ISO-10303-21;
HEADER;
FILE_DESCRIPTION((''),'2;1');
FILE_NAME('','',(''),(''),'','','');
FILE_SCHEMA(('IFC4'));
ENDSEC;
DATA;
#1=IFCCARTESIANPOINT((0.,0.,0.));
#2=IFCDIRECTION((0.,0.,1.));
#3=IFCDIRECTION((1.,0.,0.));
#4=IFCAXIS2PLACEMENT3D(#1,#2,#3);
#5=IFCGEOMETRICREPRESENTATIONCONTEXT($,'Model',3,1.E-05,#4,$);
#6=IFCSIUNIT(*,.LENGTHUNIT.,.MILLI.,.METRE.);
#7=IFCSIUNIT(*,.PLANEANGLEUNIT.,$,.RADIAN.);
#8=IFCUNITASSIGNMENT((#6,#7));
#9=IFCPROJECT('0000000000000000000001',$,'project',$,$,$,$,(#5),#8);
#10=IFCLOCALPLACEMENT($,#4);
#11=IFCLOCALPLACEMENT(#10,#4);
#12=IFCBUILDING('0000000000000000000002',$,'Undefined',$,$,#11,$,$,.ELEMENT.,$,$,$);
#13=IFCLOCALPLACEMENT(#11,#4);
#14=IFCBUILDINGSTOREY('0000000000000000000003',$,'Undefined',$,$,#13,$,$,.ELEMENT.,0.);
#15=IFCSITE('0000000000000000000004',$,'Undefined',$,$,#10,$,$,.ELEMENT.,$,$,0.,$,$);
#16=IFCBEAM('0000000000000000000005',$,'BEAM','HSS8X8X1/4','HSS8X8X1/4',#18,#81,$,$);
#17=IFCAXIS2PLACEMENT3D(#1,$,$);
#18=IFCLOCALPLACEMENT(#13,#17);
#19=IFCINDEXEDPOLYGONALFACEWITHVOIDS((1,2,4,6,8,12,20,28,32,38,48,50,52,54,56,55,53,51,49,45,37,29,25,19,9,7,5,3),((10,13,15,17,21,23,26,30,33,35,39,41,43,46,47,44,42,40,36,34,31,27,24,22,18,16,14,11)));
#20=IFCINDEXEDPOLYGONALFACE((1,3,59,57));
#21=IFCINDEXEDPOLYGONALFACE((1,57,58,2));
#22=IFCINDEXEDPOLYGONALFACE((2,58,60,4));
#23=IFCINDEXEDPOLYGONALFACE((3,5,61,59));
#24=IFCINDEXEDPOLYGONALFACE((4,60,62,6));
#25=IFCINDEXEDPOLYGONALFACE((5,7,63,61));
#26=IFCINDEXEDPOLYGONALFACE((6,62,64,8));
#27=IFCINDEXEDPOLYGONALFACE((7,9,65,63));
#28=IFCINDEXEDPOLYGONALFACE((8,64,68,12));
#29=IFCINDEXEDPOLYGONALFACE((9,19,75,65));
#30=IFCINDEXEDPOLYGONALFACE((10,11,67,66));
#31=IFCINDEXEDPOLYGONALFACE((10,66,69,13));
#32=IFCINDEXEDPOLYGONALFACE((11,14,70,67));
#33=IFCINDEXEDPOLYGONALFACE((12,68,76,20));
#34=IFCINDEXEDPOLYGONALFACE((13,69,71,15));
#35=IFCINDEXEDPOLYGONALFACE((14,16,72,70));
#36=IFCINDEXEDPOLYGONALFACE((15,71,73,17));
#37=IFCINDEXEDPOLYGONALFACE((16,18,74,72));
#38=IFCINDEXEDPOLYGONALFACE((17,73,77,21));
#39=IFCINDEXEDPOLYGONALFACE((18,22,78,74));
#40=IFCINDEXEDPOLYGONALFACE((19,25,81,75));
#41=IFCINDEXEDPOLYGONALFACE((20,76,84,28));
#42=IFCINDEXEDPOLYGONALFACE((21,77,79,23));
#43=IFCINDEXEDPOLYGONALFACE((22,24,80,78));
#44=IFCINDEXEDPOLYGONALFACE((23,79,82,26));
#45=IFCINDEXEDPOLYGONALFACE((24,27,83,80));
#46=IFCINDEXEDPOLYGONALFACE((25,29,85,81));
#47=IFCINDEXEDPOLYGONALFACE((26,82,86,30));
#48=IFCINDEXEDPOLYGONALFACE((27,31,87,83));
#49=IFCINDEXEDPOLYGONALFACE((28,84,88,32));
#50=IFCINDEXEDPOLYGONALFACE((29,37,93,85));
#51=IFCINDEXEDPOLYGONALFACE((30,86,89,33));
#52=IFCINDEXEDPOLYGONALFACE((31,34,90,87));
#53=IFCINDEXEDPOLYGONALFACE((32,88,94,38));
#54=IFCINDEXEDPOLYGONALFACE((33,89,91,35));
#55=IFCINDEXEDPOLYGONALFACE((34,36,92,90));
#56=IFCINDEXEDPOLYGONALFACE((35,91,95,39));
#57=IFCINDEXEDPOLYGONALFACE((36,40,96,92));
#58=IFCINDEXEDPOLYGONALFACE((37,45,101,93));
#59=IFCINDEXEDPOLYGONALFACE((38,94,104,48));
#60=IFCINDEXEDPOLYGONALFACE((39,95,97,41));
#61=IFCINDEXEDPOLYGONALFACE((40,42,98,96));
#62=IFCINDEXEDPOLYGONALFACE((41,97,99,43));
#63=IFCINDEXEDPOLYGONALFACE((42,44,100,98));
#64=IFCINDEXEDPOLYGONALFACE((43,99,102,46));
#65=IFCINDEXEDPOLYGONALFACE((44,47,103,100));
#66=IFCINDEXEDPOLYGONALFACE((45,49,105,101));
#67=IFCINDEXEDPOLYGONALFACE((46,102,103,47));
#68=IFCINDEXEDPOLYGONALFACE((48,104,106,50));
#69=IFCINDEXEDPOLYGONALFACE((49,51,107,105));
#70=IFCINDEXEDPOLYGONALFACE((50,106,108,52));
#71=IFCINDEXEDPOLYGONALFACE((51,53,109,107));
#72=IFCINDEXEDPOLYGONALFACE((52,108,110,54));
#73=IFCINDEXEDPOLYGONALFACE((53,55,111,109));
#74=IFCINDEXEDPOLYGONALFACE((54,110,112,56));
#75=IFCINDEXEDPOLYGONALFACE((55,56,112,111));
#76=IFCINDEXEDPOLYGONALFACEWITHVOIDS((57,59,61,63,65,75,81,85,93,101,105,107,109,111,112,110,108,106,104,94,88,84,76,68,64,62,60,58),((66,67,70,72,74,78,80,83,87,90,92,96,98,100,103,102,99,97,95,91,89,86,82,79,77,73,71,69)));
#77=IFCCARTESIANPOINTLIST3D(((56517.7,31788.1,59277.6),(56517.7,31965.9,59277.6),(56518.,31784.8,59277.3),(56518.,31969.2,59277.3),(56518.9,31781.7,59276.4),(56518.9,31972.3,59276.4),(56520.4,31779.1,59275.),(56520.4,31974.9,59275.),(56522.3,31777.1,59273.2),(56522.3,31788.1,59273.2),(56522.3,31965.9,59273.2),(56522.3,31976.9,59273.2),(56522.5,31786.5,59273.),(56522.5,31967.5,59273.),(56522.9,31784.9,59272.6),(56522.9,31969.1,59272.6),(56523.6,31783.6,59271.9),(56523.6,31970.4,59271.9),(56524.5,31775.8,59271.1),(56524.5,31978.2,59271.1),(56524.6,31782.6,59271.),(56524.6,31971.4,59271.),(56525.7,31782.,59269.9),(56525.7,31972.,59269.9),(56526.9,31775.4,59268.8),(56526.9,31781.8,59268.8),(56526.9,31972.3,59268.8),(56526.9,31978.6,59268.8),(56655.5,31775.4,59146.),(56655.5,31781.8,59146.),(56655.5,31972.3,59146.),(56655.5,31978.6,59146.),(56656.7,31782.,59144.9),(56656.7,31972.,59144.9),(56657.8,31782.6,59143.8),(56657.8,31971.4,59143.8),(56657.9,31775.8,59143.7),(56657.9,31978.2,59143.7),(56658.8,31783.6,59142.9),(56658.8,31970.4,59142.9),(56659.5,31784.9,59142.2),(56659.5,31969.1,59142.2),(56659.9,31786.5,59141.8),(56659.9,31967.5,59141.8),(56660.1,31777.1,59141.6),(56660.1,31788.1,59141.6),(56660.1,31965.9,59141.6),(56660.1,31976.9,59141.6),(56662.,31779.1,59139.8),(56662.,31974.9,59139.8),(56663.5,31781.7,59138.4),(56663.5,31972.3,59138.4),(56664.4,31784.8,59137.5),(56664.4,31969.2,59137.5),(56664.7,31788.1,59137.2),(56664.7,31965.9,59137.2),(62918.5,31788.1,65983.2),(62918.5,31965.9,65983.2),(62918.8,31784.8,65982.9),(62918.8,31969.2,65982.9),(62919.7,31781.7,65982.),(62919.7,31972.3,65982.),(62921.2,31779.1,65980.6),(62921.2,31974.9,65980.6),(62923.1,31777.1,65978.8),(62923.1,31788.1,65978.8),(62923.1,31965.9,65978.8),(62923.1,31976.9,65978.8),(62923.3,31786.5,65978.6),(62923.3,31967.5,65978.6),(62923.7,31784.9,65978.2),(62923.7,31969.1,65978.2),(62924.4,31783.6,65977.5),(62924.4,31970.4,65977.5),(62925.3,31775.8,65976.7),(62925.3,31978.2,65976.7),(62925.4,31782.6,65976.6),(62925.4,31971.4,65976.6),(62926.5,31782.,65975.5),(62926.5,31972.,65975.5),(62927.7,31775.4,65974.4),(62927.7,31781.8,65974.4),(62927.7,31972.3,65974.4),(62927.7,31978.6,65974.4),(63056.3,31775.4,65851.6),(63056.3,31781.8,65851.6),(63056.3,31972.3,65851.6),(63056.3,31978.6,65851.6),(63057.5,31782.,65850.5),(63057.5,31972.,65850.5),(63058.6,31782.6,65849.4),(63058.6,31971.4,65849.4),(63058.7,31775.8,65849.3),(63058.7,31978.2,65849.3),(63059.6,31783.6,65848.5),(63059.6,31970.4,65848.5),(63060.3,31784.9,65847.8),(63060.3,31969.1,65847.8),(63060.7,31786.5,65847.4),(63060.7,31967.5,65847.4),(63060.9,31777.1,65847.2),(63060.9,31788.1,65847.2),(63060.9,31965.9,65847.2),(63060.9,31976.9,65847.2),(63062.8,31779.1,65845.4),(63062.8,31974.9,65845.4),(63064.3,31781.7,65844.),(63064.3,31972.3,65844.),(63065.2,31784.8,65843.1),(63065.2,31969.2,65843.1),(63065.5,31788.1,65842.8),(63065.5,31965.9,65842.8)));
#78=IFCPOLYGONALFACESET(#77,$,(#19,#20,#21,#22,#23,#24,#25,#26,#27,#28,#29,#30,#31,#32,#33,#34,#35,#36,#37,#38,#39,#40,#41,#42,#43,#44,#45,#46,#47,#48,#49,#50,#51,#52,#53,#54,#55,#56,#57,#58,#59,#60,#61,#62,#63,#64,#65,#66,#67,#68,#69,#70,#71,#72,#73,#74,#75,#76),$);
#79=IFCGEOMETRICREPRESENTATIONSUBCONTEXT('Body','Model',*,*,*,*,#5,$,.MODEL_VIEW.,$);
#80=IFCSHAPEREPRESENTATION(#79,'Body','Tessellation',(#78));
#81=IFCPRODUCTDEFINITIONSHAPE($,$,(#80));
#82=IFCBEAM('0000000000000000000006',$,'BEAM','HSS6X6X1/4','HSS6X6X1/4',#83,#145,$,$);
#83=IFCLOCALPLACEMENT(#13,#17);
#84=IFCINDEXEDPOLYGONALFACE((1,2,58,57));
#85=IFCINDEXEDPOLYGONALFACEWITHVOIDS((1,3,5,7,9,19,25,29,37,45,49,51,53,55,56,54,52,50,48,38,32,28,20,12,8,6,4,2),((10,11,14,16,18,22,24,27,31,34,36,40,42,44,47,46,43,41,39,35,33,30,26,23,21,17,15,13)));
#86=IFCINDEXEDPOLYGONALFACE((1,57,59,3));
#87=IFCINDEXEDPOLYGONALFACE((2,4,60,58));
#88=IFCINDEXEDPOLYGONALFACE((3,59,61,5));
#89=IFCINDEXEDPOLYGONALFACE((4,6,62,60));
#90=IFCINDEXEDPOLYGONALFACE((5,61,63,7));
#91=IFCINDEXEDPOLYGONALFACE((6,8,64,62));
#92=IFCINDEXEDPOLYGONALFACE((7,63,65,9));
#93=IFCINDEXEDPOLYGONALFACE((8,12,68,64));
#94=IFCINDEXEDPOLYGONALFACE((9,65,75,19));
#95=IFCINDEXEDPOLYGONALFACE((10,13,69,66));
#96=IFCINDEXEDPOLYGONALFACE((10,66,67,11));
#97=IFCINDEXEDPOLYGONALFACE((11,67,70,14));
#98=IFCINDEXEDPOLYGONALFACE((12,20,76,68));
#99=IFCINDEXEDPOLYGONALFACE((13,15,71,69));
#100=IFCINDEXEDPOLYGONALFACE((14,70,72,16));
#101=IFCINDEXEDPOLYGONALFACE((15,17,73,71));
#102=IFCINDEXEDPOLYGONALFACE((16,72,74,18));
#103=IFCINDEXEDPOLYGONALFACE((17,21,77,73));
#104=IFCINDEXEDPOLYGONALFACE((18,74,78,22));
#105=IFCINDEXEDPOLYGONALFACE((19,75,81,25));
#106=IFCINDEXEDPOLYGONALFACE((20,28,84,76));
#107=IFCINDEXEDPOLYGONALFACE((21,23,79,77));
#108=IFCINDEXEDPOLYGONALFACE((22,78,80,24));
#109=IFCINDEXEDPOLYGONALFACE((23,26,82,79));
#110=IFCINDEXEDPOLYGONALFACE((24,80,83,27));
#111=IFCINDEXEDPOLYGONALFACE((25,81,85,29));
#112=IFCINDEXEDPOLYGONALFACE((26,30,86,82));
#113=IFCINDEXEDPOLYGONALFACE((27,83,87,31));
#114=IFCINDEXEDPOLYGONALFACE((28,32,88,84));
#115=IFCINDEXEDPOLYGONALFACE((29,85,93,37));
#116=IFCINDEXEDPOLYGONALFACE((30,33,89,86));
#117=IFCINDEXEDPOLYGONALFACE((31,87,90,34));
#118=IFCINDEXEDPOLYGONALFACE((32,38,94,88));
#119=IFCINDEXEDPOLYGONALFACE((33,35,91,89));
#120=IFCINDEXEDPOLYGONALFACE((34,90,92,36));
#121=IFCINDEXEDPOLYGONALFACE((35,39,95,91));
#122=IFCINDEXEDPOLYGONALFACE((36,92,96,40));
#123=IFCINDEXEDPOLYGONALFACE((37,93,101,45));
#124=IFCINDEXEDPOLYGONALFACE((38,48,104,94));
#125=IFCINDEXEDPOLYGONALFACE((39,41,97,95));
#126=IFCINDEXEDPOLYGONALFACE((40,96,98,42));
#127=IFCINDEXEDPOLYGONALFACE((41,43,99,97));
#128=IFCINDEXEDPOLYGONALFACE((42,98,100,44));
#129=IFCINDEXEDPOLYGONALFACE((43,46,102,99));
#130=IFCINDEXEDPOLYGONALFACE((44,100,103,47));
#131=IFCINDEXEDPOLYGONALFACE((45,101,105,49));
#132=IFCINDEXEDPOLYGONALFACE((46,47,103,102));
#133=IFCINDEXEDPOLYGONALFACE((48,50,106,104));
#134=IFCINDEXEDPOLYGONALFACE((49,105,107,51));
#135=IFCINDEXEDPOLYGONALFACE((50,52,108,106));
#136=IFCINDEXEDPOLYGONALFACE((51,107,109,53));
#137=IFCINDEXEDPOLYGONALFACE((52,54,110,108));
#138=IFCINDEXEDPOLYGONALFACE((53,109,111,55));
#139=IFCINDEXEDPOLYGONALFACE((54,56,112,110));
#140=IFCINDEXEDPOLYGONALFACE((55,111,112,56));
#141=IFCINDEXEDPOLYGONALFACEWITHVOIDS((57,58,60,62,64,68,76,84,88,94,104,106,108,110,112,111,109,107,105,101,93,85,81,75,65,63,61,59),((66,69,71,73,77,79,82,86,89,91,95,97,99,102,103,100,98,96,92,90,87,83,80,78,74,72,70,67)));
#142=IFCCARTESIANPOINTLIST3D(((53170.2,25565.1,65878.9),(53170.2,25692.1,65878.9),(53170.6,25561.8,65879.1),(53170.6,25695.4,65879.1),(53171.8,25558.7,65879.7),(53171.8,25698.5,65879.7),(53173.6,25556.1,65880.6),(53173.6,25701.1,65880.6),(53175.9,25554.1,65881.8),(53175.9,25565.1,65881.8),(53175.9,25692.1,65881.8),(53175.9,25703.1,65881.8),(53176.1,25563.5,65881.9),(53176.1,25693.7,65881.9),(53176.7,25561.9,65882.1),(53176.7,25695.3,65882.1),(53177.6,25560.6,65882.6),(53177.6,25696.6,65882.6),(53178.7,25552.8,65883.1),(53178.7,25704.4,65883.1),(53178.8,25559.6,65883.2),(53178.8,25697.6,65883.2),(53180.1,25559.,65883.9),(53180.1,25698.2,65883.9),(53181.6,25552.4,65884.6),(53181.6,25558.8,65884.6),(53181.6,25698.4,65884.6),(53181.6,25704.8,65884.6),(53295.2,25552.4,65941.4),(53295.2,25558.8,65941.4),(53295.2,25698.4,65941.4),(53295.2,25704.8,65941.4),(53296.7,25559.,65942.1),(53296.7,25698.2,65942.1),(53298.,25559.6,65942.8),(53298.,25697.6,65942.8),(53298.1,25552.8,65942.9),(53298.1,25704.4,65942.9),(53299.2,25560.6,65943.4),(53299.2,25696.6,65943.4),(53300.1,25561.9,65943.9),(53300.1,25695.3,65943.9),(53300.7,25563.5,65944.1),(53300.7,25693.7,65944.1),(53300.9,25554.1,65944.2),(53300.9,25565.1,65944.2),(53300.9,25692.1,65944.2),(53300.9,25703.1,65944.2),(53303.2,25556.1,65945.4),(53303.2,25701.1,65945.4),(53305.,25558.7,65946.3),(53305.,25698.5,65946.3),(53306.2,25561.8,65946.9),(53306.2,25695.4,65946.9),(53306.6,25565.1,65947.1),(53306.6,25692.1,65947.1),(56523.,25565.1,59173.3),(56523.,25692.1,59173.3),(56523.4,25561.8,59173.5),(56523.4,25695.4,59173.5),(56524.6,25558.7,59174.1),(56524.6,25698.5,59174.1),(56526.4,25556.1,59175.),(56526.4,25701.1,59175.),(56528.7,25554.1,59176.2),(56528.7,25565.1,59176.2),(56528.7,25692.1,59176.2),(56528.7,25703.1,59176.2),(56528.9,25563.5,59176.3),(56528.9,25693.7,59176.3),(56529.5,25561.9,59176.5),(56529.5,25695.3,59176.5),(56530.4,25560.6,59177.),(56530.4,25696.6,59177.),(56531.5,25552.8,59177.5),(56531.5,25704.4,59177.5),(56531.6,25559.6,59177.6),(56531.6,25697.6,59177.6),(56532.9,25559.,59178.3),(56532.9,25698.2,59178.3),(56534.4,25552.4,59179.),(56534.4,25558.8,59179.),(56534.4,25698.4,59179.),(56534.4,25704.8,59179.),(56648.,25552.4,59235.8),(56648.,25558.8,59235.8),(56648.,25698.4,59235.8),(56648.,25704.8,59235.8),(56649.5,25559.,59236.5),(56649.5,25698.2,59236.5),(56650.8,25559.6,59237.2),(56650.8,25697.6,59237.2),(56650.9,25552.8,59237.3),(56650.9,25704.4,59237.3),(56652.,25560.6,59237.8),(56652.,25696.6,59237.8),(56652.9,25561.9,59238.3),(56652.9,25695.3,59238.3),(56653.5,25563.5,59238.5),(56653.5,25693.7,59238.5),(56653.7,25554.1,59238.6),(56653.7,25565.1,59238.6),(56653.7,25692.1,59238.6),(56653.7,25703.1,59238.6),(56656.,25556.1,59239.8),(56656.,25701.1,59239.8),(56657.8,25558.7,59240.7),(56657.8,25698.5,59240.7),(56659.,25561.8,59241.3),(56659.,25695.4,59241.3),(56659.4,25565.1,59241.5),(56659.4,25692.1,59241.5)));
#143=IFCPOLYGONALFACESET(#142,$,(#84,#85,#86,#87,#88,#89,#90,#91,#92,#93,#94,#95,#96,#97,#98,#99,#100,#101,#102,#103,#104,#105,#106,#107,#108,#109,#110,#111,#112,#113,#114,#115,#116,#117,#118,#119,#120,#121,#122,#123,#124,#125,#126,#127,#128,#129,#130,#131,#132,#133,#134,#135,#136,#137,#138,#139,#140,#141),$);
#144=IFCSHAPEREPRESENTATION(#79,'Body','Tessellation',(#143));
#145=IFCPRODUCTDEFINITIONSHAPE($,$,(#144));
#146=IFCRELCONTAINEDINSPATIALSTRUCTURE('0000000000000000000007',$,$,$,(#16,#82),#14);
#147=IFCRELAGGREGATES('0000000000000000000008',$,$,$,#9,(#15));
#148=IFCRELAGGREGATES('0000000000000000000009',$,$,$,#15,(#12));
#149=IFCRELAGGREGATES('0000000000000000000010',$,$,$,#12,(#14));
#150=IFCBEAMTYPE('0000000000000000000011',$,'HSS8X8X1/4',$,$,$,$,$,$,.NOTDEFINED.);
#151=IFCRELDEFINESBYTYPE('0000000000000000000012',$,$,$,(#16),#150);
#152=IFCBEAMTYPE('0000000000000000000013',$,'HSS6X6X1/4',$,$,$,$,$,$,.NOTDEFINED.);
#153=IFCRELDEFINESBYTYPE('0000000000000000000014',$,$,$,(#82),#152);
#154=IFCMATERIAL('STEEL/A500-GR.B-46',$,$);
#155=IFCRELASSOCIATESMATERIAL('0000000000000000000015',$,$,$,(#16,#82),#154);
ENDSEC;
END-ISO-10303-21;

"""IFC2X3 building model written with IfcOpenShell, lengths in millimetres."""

from ifc_helpers import new_model, si_unit, frame, origin_with_axes, origin_2d_with_axis, place, context, subcontext, project, spatial, hollow_rectangle, extrude, material, type_object, element, save


model = new_model("IFC2X3")

# Units and contexts
model_context = context("Model", 3, precision=1e-05, world=origin_with_axes())
body_context = subcontext(model_context, "Body", "Model", "MODEL_VIEW")
ifc_project = project(units=[si_unit("LENGTHUNIT", "METRE", prefix="MILLI"), si_unit("PLANEANGLEUNIT", "RADIAN")], contexts=[model_context])

# Site, building, storey
site_placement = place(None, origin_with_axes())
site = spatial("IfcSite", under=ifc_project, at=site_placement, Name="Undefined", CompositionType="ELEMENT", RefElevation=0.0)
building_placement = place(site_placement, origin_with_axes())
building = spatial("IfcBuilding", under=site, at=building_placement, Name="Undefined", CompositionType="ELEMENT")
storey_placement = place(building_placement, origin_with_axes())
storey = spatial("IfcBuildingStorey", under=building, at=storey_placement, Name="Undefined", CompositionType="ELEMENT", Elevation=0.0)

# Beams
ifc_material_1 = material(Name="STEEL/A500-GR.B-46")
beam_type_1 = type_object("IfcBeamType", Name="HSS8X8X1/4", PredefinedType="NOTDEFINED")
beam_1_placement = place(storey_placement, frame((56591.2, 31877.0, 59207.4), z_axis=(-0.723356, 0.0, 0.690476), x_axis=(0.690476, 0.0, 0.723356)))
element("IfcBeam", 1, at=beam_1_placement, inside=storey, type_object=beam_type_1, material=ifc_material_1, Name="BEAM", Description="HSS8X8X1/4", ObjectType="HSS8X8X1/4", context=body_context, shape_type="SweptSolid", body=[
    extrude(hollow_rectangle(XDim=203.2, YDim=203.2, WallThickness=6.3, InnerFilletRadius=6.3, OuterFilletRadius=12.7, at=origin_2d_with_axis()), frame((9270.1, 0.0, 0.0), z_axis=(-1.0, 0.0, 0.0), x_axis=(0.0, -1.0, 0.0)), (0.0, 0.0, 1.0), 9270.1),
])
beam_type_2 = type_object("IfcBeamType", Name="HSS6X6X1/4", PredefinedType="NOTDEFINED")
beam_2_placement = place(storey_placement, frame((56591.2, 25628.6, 59207.4), z_axis=(0.894427, 0.0, 0.447214), x_axis=(-0.447214, 0.0, 0.894427)))
element("IfcBeam", 2, at=beam_2_placement, inside=storey, type_object=beam_type_2, material=ifc_material_1, Name="BEAM", Description="HSS6X6X1/4", ObjectType="HSS6X6X1/4", context=body_context, shape_type="SweptSolid", body=[
    extrude(hollow_rectangle(XDim=152.4, YDim=152.4, WallThickness=6.3, InnerFilletRadius=6.3, OuterFilletRadius=12.7, at=origin_2d_with_axis()), frame((7497.1, 0.0, 0.0), z_axis=(-1.0, 0.0, 0.0), x_axis=(0.0, -1.0, 0.0)), (0.0, 0.0, 1.0), 7497.1),
])

save(model, "model.ifc")
